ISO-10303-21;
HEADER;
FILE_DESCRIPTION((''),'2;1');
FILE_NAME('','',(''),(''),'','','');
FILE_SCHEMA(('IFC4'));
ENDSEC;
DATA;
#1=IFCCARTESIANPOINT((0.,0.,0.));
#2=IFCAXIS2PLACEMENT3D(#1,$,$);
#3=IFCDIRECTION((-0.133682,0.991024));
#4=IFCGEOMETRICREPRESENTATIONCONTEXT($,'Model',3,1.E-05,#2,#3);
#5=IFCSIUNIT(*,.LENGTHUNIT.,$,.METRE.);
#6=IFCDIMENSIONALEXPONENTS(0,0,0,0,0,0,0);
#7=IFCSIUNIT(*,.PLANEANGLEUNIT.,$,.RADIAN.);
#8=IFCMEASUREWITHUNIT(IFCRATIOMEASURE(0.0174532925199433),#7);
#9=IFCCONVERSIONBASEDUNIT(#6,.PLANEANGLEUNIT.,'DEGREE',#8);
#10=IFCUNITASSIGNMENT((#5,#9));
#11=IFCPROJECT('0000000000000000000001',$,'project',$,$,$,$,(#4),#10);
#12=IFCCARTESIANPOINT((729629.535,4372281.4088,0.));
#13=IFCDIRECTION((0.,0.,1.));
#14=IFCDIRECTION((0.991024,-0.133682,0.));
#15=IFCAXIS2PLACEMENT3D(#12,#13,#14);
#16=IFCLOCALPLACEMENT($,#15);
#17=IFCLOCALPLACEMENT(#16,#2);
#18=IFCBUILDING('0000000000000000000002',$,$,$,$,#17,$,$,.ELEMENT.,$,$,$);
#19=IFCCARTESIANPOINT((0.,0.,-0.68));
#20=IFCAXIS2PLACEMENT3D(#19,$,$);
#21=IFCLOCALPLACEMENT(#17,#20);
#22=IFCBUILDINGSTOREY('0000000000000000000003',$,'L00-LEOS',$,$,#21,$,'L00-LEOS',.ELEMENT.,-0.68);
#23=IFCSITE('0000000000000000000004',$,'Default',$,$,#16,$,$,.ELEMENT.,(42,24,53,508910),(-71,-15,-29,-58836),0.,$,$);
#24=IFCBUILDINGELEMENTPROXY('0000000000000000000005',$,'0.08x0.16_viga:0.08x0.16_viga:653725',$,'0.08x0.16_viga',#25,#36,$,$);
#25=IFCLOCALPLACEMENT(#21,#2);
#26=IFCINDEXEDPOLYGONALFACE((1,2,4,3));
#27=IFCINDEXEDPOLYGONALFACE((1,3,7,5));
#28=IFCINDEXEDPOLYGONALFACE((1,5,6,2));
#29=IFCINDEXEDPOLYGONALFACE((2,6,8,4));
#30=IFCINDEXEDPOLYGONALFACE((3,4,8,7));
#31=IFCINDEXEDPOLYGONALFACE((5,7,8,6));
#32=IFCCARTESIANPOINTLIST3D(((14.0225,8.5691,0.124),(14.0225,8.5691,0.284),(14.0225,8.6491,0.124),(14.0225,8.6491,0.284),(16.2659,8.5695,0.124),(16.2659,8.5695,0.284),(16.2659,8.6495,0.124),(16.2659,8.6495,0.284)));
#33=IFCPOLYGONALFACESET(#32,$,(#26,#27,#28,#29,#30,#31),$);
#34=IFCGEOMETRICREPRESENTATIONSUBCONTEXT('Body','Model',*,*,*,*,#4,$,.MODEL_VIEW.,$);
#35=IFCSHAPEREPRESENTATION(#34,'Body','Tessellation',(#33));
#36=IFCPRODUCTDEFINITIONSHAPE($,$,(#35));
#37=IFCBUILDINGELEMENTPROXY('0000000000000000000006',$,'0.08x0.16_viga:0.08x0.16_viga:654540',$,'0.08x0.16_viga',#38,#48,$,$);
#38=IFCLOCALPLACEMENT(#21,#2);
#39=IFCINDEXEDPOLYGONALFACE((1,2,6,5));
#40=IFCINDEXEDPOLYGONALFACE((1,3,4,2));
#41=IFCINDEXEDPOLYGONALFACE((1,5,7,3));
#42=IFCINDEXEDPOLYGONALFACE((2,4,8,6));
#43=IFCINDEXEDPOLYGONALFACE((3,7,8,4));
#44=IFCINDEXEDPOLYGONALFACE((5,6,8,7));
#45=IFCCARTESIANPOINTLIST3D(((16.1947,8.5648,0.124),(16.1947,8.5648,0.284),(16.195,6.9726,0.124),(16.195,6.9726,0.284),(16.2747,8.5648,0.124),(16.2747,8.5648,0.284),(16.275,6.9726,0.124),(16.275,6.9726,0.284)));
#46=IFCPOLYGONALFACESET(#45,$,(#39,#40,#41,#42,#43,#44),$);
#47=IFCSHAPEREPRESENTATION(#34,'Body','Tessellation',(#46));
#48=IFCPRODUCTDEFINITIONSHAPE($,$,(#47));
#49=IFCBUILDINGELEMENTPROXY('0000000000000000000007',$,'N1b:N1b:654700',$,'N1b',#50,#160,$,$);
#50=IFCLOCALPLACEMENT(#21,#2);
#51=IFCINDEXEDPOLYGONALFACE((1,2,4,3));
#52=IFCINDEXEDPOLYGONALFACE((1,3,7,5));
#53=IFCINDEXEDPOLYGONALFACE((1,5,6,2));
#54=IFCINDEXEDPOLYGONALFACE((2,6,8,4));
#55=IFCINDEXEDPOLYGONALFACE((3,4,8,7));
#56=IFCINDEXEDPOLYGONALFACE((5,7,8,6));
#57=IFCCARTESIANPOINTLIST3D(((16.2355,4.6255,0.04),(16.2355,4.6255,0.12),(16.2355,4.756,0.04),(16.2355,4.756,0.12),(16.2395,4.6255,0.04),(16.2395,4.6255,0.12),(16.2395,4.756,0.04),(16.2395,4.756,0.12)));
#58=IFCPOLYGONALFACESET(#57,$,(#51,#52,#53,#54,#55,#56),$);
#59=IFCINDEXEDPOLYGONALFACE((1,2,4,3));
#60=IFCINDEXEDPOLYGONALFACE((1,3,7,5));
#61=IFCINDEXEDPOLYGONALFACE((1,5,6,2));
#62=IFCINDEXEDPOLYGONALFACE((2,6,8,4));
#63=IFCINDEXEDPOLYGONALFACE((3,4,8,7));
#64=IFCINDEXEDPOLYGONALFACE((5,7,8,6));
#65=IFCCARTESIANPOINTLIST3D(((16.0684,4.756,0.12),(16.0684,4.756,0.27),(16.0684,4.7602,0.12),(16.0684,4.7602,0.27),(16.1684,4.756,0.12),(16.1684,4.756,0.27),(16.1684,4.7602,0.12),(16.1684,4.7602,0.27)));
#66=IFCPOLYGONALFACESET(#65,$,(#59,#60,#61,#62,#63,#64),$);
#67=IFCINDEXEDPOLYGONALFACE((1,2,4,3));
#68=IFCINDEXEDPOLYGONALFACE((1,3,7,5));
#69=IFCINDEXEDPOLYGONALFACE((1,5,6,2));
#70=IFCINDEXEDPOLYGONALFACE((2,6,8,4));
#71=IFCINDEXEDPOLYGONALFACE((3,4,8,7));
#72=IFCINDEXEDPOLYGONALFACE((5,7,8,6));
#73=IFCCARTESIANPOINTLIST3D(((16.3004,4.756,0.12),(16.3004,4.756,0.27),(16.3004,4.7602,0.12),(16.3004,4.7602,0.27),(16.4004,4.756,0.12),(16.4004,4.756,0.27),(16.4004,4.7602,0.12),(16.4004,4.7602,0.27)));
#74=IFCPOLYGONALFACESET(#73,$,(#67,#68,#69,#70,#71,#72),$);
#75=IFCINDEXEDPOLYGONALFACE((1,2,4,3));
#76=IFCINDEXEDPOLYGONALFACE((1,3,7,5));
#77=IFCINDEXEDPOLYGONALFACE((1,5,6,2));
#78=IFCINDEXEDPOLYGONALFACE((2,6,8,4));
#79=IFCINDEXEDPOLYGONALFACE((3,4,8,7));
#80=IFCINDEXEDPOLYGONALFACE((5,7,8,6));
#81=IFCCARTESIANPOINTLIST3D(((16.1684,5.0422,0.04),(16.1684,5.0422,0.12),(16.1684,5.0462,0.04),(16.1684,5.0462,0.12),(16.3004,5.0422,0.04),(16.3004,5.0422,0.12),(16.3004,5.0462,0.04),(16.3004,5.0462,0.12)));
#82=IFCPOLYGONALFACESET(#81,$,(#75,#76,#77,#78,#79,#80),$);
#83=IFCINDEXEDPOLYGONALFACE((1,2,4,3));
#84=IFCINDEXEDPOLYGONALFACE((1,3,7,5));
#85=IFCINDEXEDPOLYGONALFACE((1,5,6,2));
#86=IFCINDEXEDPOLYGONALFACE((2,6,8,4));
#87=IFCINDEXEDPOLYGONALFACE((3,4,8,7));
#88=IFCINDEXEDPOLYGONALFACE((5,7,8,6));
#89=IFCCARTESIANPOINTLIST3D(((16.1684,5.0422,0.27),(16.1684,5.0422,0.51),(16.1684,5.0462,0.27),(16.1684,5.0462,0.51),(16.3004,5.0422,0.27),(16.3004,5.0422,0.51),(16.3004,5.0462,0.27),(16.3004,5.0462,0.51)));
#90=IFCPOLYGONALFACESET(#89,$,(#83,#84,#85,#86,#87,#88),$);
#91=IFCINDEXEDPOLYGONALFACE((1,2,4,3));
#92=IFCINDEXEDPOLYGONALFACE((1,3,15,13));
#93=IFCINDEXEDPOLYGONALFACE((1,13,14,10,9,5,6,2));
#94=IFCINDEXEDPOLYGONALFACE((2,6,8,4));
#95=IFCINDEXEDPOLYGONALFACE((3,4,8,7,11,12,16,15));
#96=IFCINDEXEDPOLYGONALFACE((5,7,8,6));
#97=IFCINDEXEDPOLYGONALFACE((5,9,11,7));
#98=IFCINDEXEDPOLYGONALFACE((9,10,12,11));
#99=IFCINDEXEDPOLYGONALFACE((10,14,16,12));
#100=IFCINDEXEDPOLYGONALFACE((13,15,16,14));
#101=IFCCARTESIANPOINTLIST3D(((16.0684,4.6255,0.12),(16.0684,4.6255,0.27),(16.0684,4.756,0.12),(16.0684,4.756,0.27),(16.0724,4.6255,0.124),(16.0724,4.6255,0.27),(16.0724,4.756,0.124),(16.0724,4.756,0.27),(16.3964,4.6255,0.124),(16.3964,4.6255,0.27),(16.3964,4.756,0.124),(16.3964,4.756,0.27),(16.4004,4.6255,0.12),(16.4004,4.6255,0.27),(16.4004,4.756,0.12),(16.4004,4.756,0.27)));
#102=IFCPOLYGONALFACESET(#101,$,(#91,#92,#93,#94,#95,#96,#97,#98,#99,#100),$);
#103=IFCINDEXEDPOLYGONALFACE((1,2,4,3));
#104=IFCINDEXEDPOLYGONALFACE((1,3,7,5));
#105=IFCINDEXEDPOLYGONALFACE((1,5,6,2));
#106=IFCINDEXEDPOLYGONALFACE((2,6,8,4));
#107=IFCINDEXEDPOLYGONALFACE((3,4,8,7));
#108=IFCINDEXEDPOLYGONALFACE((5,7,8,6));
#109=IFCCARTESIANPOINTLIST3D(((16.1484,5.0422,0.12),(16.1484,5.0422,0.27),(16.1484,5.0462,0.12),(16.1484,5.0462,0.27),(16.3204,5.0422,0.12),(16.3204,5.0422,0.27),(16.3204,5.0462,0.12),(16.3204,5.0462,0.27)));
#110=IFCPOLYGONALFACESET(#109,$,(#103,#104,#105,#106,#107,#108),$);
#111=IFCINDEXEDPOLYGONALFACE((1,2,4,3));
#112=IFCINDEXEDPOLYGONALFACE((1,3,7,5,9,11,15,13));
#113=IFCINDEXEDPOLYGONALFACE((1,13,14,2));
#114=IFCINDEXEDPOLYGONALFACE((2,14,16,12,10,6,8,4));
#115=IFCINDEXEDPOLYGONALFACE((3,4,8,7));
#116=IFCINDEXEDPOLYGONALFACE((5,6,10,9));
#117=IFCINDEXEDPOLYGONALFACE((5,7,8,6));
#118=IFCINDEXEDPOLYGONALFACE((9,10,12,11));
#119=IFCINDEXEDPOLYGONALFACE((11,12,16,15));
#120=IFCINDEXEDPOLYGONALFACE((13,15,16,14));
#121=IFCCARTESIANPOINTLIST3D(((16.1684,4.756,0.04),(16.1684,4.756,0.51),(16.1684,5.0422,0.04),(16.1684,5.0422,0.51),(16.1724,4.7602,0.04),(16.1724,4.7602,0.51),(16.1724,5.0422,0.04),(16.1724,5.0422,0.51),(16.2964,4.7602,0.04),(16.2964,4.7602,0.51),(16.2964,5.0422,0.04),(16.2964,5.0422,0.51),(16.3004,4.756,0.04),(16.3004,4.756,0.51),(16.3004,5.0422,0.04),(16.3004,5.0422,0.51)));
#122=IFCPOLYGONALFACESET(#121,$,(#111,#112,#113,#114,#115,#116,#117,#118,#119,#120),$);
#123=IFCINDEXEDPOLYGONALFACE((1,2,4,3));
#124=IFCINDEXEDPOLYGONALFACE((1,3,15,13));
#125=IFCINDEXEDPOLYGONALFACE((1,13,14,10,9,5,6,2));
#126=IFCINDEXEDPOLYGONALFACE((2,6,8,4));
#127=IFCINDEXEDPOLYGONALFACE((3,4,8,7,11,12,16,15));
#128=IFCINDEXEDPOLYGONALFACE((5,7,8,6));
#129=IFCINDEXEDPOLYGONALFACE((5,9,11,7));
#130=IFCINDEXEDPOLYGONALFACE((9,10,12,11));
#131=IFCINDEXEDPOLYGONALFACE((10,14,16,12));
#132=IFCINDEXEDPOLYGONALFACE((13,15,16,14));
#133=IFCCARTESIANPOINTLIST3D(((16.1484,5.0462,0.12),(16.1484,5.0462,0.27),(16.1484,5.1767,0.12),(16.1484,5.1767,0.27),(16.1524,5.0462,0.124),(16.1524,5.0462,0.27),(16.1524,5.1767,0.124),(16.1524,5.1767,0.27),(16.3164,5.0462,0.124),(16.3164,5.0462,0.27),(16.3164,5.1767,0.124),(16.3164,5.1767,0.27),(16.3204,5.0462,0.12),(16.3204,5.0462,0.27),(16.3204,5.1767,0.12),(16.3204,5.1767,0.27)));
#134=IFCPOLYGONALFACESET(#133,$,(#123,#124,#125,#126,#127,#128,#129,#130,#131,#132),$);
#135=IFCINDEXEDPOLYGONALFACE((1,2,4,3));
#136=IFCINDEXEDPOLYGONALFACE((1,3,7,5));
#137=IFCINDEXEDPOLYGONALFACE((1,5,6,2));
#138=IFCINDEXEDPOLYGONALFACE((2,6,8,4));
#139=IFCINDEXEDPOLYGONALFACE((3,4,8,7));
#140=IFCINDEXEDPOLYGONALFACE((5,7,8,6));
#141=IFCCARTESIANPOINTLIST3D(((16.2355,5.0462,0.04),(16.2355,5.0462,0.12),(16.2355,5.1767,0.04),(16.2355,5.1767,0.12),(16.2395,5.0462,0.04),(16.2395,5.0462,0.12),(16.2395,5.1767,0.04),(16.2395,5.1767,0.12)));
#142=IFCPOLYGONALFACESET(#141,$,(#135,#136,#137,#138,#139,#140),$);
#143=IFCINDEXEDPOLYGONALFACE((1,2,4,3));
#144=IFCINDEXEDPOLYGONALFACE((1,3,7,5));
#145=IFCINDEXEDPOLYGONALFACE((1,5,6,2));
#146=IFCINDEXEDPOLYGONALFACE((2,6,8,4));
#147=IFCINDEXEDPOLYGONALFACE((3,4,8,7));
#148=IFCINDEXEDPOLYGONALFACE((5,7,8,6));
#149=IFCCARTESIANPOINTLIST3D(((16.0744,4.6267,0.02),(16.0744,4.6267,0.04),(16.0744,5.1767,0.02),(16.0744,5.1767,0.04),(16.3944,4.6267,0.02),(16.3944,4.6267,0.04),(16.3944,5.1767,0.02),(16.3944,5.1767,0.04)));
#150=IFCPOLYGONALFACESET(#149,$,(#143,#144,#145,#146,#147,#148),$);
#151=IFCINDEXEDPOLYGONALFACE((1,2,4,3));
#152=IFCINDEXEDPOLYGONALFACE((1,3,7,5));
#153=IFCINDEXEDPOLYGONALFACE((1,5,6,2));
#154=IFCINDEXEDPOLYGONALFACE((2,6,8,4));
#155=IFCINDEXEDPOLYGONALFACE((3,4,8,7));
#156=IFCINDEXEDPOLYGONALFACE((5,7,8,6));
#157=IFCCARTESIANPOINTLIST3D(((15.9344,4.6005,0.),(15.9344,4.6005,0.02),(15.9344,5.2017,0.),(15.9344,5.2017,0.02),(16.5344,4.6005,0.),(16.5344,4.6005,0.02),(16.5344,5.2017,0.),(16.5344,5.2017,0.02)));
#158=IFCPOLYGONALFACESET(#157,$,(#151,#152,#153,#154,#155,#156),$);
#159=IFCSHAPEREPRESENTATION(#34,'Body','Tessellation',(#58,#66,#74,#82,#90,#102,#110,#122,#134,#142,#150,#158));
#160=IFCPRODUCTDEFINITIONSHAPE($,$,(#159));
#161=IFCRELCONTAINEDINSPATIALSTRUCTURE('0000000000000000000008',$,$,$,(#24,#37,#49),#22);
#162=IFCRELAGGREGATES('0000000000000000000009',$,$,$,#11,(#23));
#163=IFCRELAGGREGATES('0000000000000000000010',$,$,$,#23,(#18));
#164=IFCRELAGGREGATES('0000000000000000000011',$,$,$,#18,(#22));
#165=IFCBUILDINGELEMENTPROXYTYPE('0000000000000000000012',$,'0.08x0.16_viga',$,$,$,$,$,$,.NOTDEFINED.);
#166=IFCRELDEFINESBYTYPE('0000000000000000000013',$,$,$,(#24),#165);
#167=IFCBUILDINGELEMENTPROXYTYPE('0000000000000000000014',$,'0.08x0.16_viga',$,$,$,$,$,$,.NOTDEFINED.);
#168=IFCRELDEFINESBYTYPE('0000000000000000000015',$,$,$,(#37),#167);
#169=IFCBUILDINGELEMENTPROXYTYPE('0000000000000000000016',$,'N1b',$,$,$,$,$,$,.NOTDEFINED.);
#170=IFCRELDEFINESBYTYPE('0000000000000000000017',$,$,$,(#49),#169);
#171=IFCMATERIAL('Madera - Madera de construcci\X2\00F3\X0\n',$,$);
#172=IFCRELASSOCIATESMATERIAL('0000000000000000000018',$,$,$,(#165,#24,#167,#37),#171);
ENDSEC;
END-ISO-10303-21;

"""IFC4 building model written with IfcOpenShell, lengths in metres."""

from ifc_helpers import new_model, entity, si_unit, converted_unit, direction, frame, frame_2d, origin, origin_2d_with_axis, place, context, subcontext, project, spatial, polyline, rectangle, outline, extrude, source, transform, mapped, material, type_object, type_shapes, element, save


model = new_model("IFC4")

# Units and contexts
model_context = context("Model", 3, precision=1e-05, world=origin(), true_north=direction((-0.133682, 0.991024)))
body_context = subcontext(model_context, "Body", "Model", "MODEL_VIEW")
ifc_project = project(units=[si_unit("LENGTHUNIT", "METRE"), converted_unit("PLANEANGLEUNIT", "DEGREE", entity("IfcRatioMeasure", 0.0174532925199433), si_unit("PLANEANGLEUNIT", "RADIAN"), dimensions=[0, 0, 0, 0, 0, 0, 0])], contexts=[model_context])

# Site, building, storey
site_placement = place(None, frame((729629.535, 4372281.4088, 0.0), z_axis=(0.0, 0.0, 1.0), x_axis=(0.991024, -0.133682, 0.0)))
site = spatial("IfcSite", under=ifc_project, at=site_placement, Name="Default", CompositionType="ELEMENT", RefLatitude=(42, 24, 53, 508910), RefLongitude=(-71, -15, -29, -58836), RefElevation=0.0)
building_placement = place(site_placement, origin())
building = spatial("IfcBuilding", under=site, at=building_placement, CompositionType="ELEMENT")
storey_placement = place(building_placement, frame((0.0, 0.0, -0.68)))
storey = spatial("IfcBuildingStorey", under=building, at=storey_placement, Name="L00-LEOS", LongName="L00-LEOS", CompositionType="ELEMENT", Elevation=-0.68)

# Building element proxies
ifc_material = material(Name="Madera - Madera de construcción")
building_element_proxy_type_1 = type_object("IfcBuildingElementProxyType", Name="0.08x0.16_viga", material=ifc_material)
shared_shape_1 = source(origin(), body_context, "Body", "SweptSolid", [
    extrude(rectangle(XDim=0.08, YDim=2.2434, at=origin_2d_with_axis()), frame((0.0867, 0.0, 0.0), z_axis=(0.0, 0.0, 1.0), x_axis=(0.0, -1.0, 0.0)), (0.0, 0.0, 1.0), 0.16),
])
type_shapes(building_element_proxy_type_1, [shared_shape_1])
proxy_1_placement = place(storey_placement, frame((15.0575, 8.6093, 0.124), z_axis=(0.0, 0.0, 1.0), x_axis=(1.0, 0.000179, 0.0)))
element("IfcBuildingElementProxy", 1, at=proxy_1_placement, inside=storey, type_object=building_element_proxy_type_1, material=ifc_material, Name="0.08x0.16_viga:0.08x0.16_viga:653725", ObjectType="0.08x0.16_viga", context=body_context, shape_type="MappedRepresentation", body=[
    mapped(shared_shape_1, transform((0.0, 0.0, 0.0), scale=1.0)),
])
building_element_proxy_type_2 = type_object("IfcBuildingElementProxyType", Name="0.08x0.16_viga", material=ifc_material)
shared_shape_2 = source(origin(), body_context, "Body", "SweptSolid", [
    extrude(rectangle(XDim=0.08, YDim=1.5922, at=origin_2d_with_axis()), frame((-0.2389, 0.0, 0.0), z_axis=(0.0, 0.0, 1.0), x_axis=(0.0, -1.0, 0.0)), (0.0, 0.0, 1.0), 0.16),
])
type_shapes(building_element_proxy_type_2, [shared_shape_2])
proxy_2_placement = place(storey_placement, frame((16.2349, 7.5298, 0.124), z_axis=(0.0, 0.0, 1.0), x_axis=(0.000179, -1.0, 0.0)))
element("IfcBuildingElementProxy", 2, at=proxy_2_placement, inside=storey, type_object=building_element_proxy_type_2, material=ifc_material, Name="0.08x0.16_viga:0.08x0.16_viga:654540", ObjectType="0.08x0.16_viga", context=body_context, shape_type="MappedRepresentation", body=[
    mapped(shared_shape_2, transform((0.0, 0.0, 0.0), scale=1.0)),
])
building_element_proxy_type_3 = type_object("IfcBuildingElementProxyType", Name="N1b")
shared_shape_3 = source(origin(), body_context, "Body", "SweptSolid", [
    extrude(rectangle(XDim=0.1305, YDim=0.004, at=origin_2d_with_axis()), frame((0.2103, 0.0, 0.04)), (0.0, 0.0, 1.0), 0.08),
    extrude(rectangle(XDim=0.0042, YDim=0.1, at=frame_2d((0.0, 0.0), x_axis=(1.0, 0.0))), frame((0.143, -0.1191, 0.12), z_axis=(0.0, 0.0, 1.0), x_axis=(-1.0, 0.0, 0.0)), (0.0, 0.0, 1.0), 0.15),
    extrude(rectangle(XDim=0.0042, YDim=0.1, at=frame_2d((0.0, 0.0), x_axis=(1.0, 0.0))), frame((0.143, 0.1129, 0.12), z_axis=(0.0, 0.0, 1.0), x_axis=(-1.0, 0.0, 0.0)), (0.0, 0.0, 1.0), 0.15),
    extrude(rectangle(XDim=0.004, YDim=0.132, at=frame_2d((0.0, 0.0), x_axis=(1.0, 0.0))), frame((-0.1431, -0.0031, 0.04), z_axis=(0.0, 0.0, 1.0), x_axis=(-1.0, 0.0, 0.0)), (0.0, 0.0, 1.0), 0.08),
    extrude(rectangle(XDim=0.004, YDim=0.132, at=frame_2d((0.0, 0.0), x_axis=(1.0, 0.0))), frame((-0.1431, -0.0031, 0.27), z_axis=(0.0, 0.0, 1.0), x_axis=(-1.0, 0.0, 0.0)), (0.0, 0.0, 1.0), 0.24),
    extrude(outline(polyline([(-0.166, -0.076), (0.166, -0.076), (0.166, 0.074), (0.162, 0.074), (0.162, -0.072), (-0.162, -0.072), (-0.162, 0.074), (-0.166, 0.074), (-0.166, -0.076)])), frame((0.1451, -0.0031, 0.196), z_axis=(1.0, 0.0, 0.0), x_axis=(0.0, 1.0, 0.0)), (0.0, 0.0, 1.0), 0.1305),
    extrude(rectangle(XDim=0.004, YDim=0.172, at=frame_2d((0.0, 0.0), x_axis=(1.0, 0.0))), frame((-0.1431, -0.0031, 0.12), z_axis=(0.0, 0.0, 1.0), x_axis=(-1.0, 0.0, 0.0)), (0.0, 0.0, 1.0), 0.15),
    extrude(outline(polyline([(-0.066, -0.1441), (0.066, -0.1441), (0.066, 0.142), (0.062, 0.142), (0.062, -0.14), (-0.062, -0.14), (-0.062, 0.142), (-0.066, 0.142), (-0.066, -0.1441)])), frame((0.001, -0.0031, 0.04), z_axis=(0.0, 0.0, 1.0), x_axis=(0.0, 1.0, 0.0)), (0.0, 0.0, 1.0), 0.47),
    extrude(outline(polyline([(-0.086, -0.076), (0.086, -0.076), (0.086, 0.074), (0.082, 0.074), (0.082, -0.072), (-0.082, -0.072), (-0.082, 0.074), (-0.086, 0.074), (-0.086, -0.076)])), frame((-0.2756, -0.0031, 0.196), z_axis=(1.0, 0.0, 0.0), x_axis=(0.0, 1.0, 0.0)), (0.0, 0.0, 1.0), 0.1305),
    extrude(rectangle(XDim=0.1305, YDim=0.004, at=origin_2d_with_axis()), frame((-0.2103, 0.0, 0.04)), (0.0, 0.0, 1.0), 0.08),
    extrude(rectangle(XDim=0.32, YDim=0.55, at=frame_2d((0.0, 0.0), x_axis=(1.0, 0.0))), frame((-0.0006, -0.0031, 0.02), z_axis=(0.0, 0.0, 1.0), x_axis=(0.0, 1.0, 0.0)), (0.0, 0.0, 1.0), 0.02),
    extrude(rectangle(XDim=0.6, YDim=0.6012, at=frame_2d((0.0, 0.0), x_axis=(1.0, 0.0))), frame((0.0, -0.0031, 0.0), z_axis=(0.0, 0.0, 1.0), x_axis=(0.0, 1.0, 0.0)), (0.0, 0.0, 1.0), 0.02),
])
type_shapes(building_element_proxy_type_3, [shared_shape_3])
proxy_3_placement = place(storey_placement, frame((16.2375, 4.9011, 0.0), z_axis=(0.0, 0.0, 1.0), x_axis=(0.0, -1.0, 0.0)))
element("IfcBuildingElementProxy", 3, at=proxy_3_placement, inside=storey, type_object=building_element_proxy_type_3, Name="N1b:N1b:654700", ObjectType="N1b", context=body_context, shape_type="MappedRepresentation", body=[
    mapped(shared_shape_3, transform((0.0, 0.0, 0.0), scale=1.0)),
])

save(model, "model.ifc")
